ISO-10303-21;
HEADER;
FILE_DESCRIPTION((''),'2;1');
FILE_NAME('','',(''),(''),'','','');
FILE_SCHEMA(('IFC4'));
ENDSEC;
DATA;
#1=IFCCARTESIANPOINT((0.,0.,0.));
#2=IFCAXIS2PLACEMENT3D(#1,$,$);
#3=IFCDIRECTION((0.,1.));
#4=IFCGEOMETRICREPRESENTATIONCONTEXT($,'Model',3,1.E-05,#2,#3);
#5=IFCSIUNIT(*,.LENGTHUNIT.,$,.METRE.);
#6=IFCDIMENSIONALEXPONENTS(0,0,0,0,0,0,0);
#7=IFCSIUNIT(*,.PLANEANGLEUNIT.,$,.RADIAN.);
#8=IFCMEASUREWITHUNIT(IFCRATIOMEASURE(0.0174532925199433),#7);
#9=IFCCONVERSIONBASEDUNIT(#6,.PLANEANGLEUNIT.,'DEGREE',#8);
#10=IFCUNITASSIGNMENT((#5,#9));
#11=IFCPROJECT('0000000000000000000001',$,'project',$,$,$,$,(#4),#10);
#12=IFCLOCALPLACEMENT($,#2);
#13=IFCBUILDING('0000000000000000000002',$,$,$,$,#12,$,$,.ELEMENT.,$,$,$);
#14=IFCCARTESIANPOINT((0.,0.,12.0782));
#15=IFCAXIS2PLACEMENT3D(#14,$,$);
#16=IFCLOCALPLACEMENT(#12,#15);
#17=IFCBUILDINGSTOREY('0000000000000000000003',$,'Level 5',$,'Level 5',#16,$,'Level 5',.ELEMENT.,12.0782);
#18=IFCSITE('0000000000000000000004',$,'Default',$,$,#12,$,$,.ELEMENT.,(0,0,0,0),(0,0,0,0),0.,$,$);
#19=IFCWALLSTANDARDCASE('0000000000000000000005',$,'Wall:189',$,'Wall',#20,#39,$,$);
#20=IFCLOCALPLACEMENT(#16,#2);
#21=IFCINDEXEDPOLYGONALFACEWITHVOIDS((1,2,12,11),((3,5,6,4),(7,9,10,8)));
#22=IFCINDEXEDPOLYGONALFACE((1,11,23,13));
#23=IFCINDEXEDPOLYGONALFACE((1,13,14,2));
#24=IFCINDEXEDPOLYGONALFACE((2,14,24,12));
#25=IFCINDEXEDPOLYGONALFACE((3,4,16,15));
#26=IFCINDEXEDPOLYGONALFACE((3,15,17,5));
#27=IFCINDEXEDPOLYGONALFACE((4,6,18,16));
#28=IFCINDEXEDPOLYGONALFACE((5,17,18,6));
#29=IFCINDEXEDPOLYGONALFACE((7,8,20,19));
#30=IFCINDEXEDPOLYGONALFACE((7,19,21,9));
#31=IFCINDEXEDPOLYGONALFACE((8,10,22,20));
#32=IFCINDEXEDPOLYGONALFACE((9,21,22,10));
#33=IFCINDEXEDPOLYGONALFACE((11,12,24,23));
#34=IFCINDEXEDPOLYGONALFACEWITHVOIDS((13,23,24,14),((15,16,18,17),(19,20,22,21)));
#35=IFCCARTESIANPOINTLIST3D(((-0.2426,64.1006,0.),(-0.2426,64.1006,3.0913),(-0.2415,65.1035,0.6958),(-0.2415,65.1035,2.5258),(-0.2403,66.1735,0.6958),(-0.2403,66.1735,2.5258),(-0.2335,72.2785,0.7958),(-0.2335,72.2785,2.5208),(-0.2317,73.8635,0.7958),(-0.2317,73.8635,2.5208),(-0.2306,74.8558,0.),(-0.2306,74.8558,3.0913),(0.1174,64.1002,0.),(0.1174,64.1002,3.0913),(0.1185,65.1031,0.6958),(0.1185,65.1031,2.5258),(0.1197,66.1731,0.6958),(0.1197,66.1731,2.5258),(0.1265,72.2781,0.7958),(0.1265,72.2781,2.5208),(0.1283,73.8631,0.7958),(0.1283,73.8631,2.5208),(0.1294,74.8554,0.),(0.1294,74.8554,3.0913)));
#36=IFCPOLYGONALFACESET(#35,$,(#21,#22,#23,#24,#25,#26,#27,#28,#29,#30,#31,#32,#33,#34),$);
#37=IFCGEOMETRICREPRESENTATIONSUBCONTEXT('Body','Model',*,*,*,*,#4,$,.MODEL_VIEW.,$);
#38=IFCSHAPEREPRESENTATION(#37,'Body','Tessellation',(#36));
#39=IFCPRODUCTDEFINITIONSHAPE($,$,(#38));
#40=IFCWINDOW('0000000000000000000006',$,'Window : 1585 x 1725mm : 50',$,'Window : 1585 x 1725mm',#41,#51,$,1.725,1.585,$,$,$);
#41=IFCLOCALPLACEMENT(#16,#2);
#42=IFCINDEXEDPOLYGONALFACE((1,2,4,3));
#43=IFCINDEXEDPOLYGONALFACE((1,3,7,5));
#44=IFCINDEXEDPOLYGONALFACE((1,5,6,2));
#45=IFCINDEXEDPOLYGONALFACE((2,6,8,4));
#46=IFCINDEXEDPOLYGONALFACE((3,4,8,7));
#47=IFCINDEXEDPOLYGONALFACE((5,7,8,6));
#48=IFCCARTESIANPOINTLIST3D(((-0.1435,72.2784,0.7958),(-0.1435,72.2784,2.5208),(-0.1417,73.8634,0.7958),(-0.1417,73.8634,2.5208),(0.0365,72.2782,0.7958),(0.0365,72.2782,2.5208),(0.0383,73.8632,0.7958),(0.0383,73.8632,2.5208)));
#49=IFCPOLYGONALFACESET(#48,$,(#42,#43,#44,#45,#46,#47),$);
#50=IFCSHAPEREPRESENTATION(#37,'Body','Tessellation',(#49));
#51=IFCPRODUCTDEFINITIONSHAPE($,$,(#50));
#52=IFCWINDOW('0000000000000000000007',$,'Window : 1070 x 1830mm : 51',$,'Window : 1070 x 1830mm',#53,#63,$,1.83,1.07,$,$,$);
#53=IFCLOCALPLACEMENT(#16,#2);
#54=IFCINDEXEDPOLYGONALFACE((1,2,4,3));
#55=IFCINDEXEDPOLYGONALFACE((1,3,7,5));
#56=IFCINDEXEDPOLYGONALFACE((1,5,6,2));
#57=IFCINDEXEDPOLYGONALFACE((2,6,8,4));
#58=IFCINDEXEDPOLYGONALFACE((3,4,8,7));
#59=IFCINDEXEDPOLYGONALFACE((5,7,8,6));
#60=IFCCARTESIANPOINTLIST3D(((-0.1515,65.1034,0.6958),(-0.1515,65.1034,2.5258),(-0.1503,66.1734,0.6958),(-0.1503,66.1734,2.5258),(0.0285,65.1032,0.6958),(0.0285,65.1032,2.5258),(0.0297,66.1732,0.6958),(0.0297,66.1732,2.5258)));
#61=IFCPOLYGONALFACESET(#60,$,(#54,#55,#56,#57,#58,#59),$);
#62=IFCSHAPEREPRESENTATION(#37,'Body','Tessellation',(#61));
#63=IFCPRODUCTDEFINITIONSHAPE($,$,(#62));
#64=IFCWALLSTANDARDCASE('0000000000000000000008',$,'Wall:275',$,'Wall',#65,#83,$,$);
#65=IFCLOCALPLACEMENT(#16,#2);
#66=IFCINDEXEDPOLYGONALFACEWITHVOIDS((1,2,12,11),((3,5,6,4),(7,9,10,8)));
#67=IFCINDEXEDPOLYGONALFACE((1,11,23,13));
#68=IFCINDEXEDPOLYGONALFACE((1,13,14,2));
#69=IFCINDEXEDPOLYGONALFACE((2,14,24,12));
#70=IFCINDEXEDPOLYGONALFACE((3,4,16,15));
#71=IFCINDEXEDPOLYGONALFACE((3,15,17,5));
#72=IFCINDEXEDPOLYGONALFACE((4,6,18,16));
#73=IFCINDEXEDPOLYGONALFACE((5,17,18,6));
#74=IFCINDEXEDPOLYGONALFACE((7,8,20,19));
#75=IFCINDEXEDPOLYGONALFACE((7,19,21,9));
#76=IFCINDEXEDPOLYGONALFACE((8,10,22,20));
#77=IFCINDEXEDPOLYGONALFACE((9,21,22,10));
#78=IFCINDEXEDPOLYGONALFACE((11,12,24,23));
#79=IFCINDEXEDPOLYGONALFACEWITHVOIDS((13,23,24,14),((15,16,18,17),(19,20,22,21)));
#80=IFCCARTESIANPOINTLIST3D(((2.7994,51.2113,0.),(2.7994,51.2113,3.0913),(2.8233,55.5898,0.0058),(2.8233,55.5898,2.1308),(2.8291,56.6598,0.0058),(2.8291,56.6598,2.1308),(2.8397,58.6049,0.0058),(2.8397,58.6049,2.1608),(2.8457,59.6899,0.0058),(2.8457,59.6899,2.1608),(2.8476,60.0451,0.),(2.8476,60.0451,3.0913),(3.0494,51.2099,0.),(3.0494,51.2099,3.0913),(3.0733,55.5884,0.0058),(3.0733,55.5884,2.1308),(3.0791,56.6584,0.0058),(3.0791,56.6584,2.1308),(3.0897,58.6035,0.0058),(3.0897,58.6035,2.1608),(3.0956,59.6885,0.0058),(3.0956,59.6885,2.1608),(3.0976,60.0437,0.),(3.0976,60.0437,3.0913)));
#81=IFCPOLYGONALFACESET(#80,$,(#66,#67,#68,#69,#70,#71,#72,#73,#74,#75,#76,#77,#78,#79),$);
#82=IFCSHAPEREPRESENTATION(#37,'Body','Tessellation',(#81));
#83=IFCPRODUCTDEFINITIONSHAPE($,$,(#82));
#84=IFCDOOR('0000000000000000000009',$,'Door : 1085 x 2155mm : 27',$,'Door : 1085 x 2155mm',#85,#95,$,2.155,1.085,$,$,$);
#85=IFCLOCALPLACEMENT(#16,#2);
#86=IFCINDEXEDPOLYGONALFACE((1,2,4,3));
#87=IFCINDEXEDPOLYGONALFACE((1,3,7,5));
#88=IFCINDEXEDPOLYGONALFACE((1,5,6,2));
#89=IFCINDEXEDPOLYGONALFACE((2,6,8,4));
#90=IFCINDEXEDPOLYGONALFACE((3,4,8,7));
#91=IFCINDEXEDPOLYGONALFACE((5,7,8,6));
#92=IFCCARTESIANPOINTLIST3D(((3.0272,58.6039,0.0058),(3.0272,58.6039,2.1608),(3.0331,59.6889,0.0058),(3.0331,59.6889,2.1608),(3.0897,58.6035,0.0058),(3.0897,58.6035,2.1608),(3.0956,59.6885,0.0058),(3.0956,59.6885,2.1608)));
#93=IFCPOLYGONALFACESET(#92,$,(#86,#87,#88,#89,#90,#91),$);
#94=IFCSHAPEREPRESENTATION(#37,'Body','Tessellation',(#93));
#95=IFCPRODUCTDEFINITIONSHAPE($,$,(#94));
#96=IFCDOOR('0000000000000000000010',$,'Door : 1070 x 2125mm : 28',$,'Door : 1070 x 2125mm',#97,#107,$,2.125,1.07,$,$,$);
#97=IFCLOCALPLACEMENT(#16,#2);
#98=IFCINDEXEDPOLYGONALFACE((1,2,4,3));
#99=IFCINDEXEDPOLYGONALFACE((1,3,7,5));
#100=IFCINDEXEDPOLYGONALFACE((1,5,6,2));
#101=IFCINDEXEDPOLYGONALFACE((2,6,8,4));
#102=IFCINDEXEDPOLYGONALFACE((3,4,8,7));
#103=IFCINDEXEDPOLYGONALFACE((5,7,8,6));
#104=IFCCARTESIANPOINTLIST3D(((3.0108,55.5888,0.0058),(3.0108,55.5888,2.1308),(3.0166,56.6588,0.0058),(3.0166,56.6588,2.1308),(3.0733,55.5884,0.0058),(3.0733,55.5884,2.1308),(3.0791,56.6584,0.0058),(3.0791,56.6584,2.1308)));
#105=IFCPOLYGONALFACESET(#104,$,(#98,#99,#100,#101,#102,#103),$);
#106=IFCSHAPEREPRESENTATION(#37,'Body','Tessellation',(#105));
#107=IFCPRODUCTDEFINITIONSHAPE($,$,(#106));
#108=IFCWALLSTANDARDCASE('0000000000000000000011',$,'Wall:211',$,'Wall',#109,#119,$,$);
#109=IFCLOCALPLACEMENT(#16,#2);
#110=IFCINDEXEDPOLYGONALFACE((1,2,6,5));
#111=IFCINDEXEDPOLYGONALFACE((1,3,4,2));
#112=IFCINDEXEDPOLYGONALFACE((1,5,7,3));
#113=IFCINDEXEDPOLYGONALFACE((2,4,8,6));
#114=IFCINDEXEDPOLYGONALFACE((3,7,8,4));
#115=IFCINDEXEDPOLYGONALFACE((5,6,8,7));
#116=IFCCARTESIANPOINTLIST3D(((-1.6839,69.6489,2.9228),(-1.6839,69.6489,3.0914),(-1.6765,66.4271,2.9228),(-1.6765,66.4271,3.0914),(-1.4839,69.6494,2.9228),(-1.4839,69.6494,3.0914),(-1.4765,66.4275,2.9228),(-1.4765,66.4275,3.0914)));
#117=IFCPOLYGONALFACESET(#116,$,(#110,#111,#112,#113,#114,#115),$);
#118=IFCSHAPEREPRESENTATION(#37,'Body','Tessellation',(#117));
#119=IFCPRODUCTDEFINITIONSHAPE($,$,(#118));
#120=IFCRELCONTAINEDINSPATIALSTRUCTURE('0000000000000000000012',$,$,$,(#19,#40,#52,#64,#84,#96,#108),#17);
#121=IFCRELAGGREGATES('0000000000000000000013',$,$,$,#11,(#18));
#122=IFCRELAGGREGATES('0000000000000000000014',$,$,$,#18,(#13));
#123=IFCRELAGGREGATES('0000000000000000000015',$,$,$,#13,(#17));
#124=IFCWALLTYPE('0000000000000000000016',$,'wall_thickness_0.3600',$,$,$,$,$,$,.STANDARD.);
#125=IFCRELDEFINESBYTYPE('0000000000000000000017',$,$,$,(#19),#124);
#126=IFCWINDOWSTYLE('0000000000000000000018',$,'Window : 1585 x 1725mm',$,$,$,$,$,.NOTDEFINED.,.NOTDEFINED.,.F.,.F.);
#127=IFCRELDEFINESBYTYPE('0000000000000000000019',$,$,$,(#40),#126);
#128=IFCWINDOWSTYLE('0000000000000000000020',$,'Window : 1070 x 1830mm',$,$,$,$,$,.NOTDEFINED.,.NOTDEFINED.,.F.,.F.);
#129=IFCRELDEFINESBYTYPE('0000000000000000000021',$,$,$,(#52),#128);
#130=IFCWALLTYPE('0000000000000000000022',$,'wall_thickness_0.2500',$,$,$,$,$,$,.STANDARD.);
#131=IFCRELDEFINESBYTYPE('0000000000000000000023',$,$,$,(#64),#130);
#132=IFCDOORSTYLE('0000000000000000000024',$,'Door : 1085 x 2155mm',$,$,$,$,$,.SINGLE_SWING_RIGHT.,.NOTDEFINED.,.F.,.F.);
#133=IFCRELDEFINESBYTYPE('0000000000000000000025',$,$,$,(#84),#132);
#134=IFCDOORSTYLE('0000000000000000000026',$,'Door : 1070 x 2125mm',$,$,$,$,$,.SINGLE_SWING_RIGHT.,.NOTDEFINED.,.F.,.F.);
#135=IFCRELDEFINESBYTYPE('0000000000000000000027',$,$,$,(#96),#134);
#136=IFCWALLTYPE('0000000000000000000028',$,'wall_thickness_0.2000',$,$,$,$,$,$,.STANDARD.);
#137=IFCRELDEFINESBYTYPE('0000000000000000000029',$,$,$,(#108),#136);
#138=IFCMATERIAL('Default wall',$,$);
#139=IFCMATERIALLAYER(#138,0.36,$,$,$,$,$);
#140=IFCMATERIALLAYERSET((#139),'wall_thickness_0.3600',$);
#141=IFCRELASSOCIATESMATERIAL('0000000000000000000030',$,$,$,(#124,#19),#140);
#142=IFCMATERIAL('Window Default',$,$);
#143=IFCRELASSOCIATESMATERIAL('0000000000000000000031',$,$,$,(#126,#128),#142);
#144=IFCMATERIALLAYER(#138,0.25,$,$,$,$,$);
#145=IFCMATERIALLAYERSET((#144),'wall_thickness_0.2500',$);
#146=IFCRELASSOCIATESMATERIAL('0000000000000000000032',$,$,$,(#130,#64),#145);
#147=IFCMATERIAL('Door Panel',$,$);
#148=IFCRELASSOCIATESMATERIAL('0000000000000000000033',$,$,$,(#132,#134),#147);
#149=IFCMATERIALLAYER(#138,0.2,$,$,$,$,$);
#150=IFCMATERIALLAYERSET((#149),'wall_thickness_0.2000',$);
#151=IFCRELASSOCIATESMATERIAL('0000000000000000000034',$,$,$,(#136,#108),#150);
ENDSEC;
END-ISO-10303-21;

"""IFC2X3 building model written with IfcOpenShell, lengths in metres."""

from ifc_helpers import new_model, entity, si_unit, converted_unit, direction, frame, frame_2d, origin, origin_2d_with_axis, place, context, subcontext, project, spatial, polyline, rectangle, outline, extrude, clip, halfspace, source, transform, mapped, material, layer, layer_set, layer_usage, type_object, type_shapes, element, fill, save


model = new_model("IFC2X3")

# Units and contexts
model_context = context("Model", 3, precision=1e-05, world=origin(), true_north=direction((0.0, 1.0)))
body_context = subcontext(model_context, "Body", "Model", "MODEL_VIEW")
ifc_project = project(units=[si_unit("LENGTHUNIT", "METRE"), converted_unit("PLANEANGLEUNIT", "DEGREE", entity("IfcRatioMeasure", 0.0174532925199433), si_unit("PLANEANGLEUNIT", "RADIAN"), dimensions=[0, 0, 0, 0, 0, 0, 0])], contexts=[model_context])

# Site, building, storey
placement_1 = place(None, origin())
site = spatial("IfcSite", under=ifc_project, at=placement_1, Name="Default", CompositionType="ELEMENT", RefLatitude=(0, 0, 0, 0), RefLongitude=(0, 0, 0, 0), RefElevation=0.0)
building = spatial("IfcBuilding", under=site, at=placement_1, CompositionType="ELEMENT")
storey_placement = place(placement_1, frame((0.0, 0.0, 12.0782)))
storey = spatial("IfcBuildingStorey", under=building, at=storey_placement, Name="Level 5", ObjectType="Level 5", LongName="Level 5", CompositionType="ELEMENT", Elevation=12.0782)

# Wall, openings, windows
ifc_material_1 = material(Name="Default wall")
ifc_layer_1 = layer(ifc_material_1, 0.36)
ifc_layer_set_1 = layer_set([ifc_layer_1], Name="wall_thickness_0.3600")
ifc_layer_usage_1 = layer_usage(ifc_layer_set_1, "AXIS2", "POSITIVE", -0.18)
wall_type_1 = type_object("IfcWallType", Name="wall_thickness_0.3600", PredefinedType="STANDARD", material=ifc_layer_set_1)
wall_1_placement = place(storey_placement, frame((-0.0506, 74.8556, 0.0), z_axis=(0.0, 0.0, 1.0), x_axis=(-0.001113, -0.999999, 0.0)))
wall_1 = element("IfcWallStandardCase", 1, at=wall_1_placement, inside=storey, type_object=wall_type_1, material=ifc_layer_usage_1, Name="Wall:189", ObjectType="Wall", context=body_context, shape_type="Clipping", body=[
    clip(extrude(outline(polyline([(10.7552, -0.18), (10.7552, 0.18), (0.0, 0.18), (0.0, -0.18), (10.7552, -0.18)])), origin(), (0.0, 0.0, 1.0), 3.0913), halfspace(frame((-0.9908, -1.1771, 4.0083), z_axis=(-0.000981, -0.389902, 0.920856), x_axis=(0.004529, 0.920844, 0.389905)), False)),
])
opening_1_placement = place(wall_1_placement, frame((0.9923, -0.18, 0.7958)))
opening_1 = element("IfcOpeningElement", 2, at=opening_1_placement, cuts=wall_1, ObjectType="Opening", context=body_context, shape_type="SweptSolid", body=[
    extrude(rectangle(XDim=1.585, YDim=1.725, at=frame_2d((0.8625, 0.7925), x_axis=(0.0, 1.0))), frame((0.0, 0.0, 0.0), z_axis=(0.0, 1.0, 0.0), x_axis=(0.0, 0.0, 1.0)), (0.0, 0.0, 1.0), 0.36),
])
opening_2_placement = place(wall_1_placement, frame((8.6823, -0.18, 0.6958)))
opening_2 = element("IfcOpeningElement", 3, at=opening_2_placement, cuts=wall_1, ObjectType="Opening", context=body_context, shape_type="SweptSolid", body=[
    extrude(rectangle(XDim=1.07, YDim=1.83, at=frame_2d((0.915, 0.535), x_axis=(0.0, 1.0))), frame((0.0, 0.0, 0.0), z_axis=(0.0, 1.0, 0.0), x_axis=(0.0, 0.0, 1.0)), (0.0, 0.0, 1.0), 0.36),
])
ifc_material_2 = material(Name="Window Default")
window_style_1 = type_object("IfcWindowStyle", Name="Window : 1585 x 1725mm", ConstructionType="NOTDEFINED", OperationType="NOTDEFINED", ParameterTakesPrecedence=False, Sizeable=False, material=ifc_material_2)
shared_shape_1 = source(origin(), body_context, "Body", "SweptSolid", [
    extrude(rectangle(XDim=0.18, YDim=1.585, at=origin_2d_with_axis()), frame((0.7925, 0.18, 0.0), z_axis=(0.0, 0.0, 1.0), x_axis=(0.0, 1.0, 0.0)), (0.0, 0.0, 1.0), 1.725),
])
type_shapes(window_style_1, [shared_shape_1])
window_1_placement = place(opening_1_placement, origin())
window_1 = element("IfcWindow", 4, at=window_1_placement, inside=storey, type_object=window_style_1, Name="Window : 1585 x 1725mm : 50", ObjectType="Window : 1585 x 1725mm", OverallHeight=1.725, OverallWidth=1.585, context=body_context, shape_type="MappedRepresentation", body=[
    mapped(shared_shape_1, transform((0.0, 0.0, 0.0), scale=1.0)),
])
fill(opening_1, window_1)
window_style_2 = type_object("IfcWindowStyle", Name="Window : 1070 x 1830mm", ConstructionType="NOTDEFINED", OperationType="NOTDEFINED", ParameterTakesPrecedence=False, Sizeable=False, material=ifc_material_2)
shared_shape_2 = source(origin(), body_context, "Body", "SweptSolid", [
    extrude(rectangle(XDim=0.18, YDim=1.07, at=origin_2d_with_axis()), frame((0.535, 0.18, 0.0), z_axis=(0.0, 0.0, 1.0), x_axis=(0.0, 1.0, 0.0)), (0.0, 0.0, 1.0), 1.83),
])
type_shapes(window_style_2, [shared_shape_2])
window_2_placement = place(opening_2_placement, origin())
window_2 = element("IfcWindow", 5, at=window_2_placement, inside=storey, type_object=window_style_2, Name="Window : 1070 x 1830mm : 51", ObjectType="Window : 1070 x 1830mm", OverallHeight=1.83, OverallWidth=1.07, context=body_context, shape_type="MappedRepresentation", body=[
    mapped(shared_shape_2, transform((0.0, 0.0, 0.0), scale=1.0)),
])
fill(opening_2, window_2)

# Shared definitions
ifc_layer_2 = layer(ifc_material_1, 0.25)
ifc_layer_set_2 = layer_set([ifc_layer_2], Name="wall_thickness_0.2500")
ifc_layer_usage_2 = layer_usage(ifc_layer_set_2, "AXIS2", "POSITIVE", -0.125)
wall_type_2 = type_object("IfcWallType", Name="wall_thickness_0.2500", PredefinedType="STANDARD", material=ifc_layer_set_2)

# Shared definitions
ifc_material_3 = material(Name="Door Panel")

# Wall, openings, doors
wall_2_placement = place(storey_placement, frame((2.9726, 60.0444, 0.0), z_axis=(0.0, 0.0, 1.0), x_axis=(-0.005454, -0.999985, 0.0)))
wall_2 = element("IfcWallStandardCase", 6, at=wall_2_placement, inside=storey, type_object=wall_type_2, material=ifc_layer_usage_2, Name="Wall:275", ObjectType="Wall", context=body_context, shape_type="Clipping", body=[
    clip(clip(extrude(outline(polyline([(8.8339, -0.125), (8.8339, 0.125), (0.0, 0.125), (0.0, -0.125), (8.8339, -0.125)])), origin(), (0.0, 0.0, 1.0), 3.0913), halfspace(frame((-15.7802, -4.2854, 4.0083), z_axis=(0.000711, -0.389903, 0.920856), x_axis=(0.000531, 0.920855, 0.389905)), False)), halfspace(frame((2.3231, -15.7134, 9.0175), z_axis=(0.391125, -0.001752, 0.920336), x_axis=(0.002692, 0.999996, 0.000759)), False)),
])
opening_3_placement = place(wall_2_placement, frame((0.3552, -0.125, 0.0058)))
opening_3 = element("IfcOpeningElement", 7, at=opening_3_placement, cuts=wall_2, ObjectType="Opening", context=body_context, shape_type="SweptSolid", body=[
    extrude(rectangle(XDim=1.085, YDim=2.155, at=frame_2d((1.0775, 0.5425), x_axis=(0.0, 1.0))), frame((0.0, 0.0, 0.0), z_axis=(0.0, 1.0, 0.0), x_axis=(0.0, 0.0, 1.0)), (0.0, 0.0, 1.0), 0.25),
])
opening_4_placement = place(wall_2_placement, frame((3.3854, -0.125, 0.0058)))
opening_4 = element("IfcOpeningElement", 8, at=opening_4_placement, cuts=wall_2, ObjectType="Opening", context=body_context, shape_type="SweptSolid", body=[
    extrude(rectangle(XDim=1.07, YDim=2.125, at=frame_2d((1.0625, 0.535), x_axis=(0.0, 1.0))), frame((0.0, 0.0, 0.0), z_axis=(0.0, 1.0, 0.0), x_axis=(0.0, 0.0, 1.0)), (0.0, 0.0, 1.0), 0.25),
])
door_style_1 = type_object("IfcDoorStyle", Name="Door : 1085 x 2155mm", ConstructionType="NOTDEFINED", OperationType="SINGLE_SWING_RIGHT", ParameterTakesPrecedence=False, Sizeable=False, material=ifc_material_3)
shared_shape_3 = source(origin(), body_context, "Body", "SweptSolid", [
    extrude(rectangle(XDim=0.0625, YDim=1.085, at=origin_2d_with_axis()), frame((0.5425, 0.2188, 0.0), z_axis=(0.0, 0.0, 1.0), x_axis=(0.0, 1.0, 0.0)), (0.0, 0.0, 1.0), 2.155),
])
type_shapes(door_style_1, [shared_shape_3])
door_1_placement = place(opening_3_placement, origin())
door_1 = element("IfcDoor", 9, at=door_1_placement, inside=storey, type_object=door_style_1, Name="Door : 1085 x 2155mm : 27", ObjectType="Door : 1085 x 2155mm", OverallHeight=2.155, OverallWidth=1.085, context=body_context, shape_type="MappedRepresentation", body=[
    mapped(shared_shape_3, transform((0.0, 0.0, 0.0), scale=1.0)),
])
fill(opening_3, door_1)
door_style_2 = type_object("IfcDoorStyle", Name="Door : 1070 x 2125mm", ConstructionType="NOTDEFINED", OperationType="SINGLE_SWING_RIGHT", ParameterTakesPrecedence=False, Sizeable=False, material=ifc_material_3)
shared_shape_4 = source(origin(), body_context, "Body", "SweptSolid", [
    extrude(rectangle(XDim=0.0625, YDim=1.07, at=origin_2d_with_axis()), frame((0.535, 0.2188, 0.0), z_axis=(0.0, 0.0, 1.0), x_axis=(0.0, 1.0, 0.0)), (0.0, 0.0, 1.0), 2.125),
])
type_shapes(door_style_2, [shared_shape_4])
door_2_placement = place(opening_4_placement, origin())
door_2 = element("IfcDoor", 10, at=door_2_placement, inside=storey, type_object=door_style_2, Name="Door : 1070 x 2125mm : 28", ObjectType="Door : 1070 x 2125mm", OverallHeight=2.125, OverallWidth=1.07, context=body_context, shape_type="MappedRepresentation", body=[
    mapped(shared_shape_4, transform((0.0, 0.0, 0.0), scale=1.0)),
])
fill(opening_4, door_2)

# Wall
ifc_layer_3 = layer(ifc_material_1, 0.2)
ifc_layer_set_3 = layer_set([ifc_layer_3], Name="wall_thickness_0.2000")
ifc_layer_usage_3 = layer_usage(ifc_layer_set_3, "AXIS2", "POSITIVE", -0.1)
wall_type_3 = type_object("IfcWallType", Name="wall_thickness_0.2000", PredefinedType="STANDARD", material=ifc_layer_set_3)
placement_2 = place(placement_1, frame((0.0, 0.0, 15.001)))
wall_3_placement = place(placement_2, frame((-1.5839, 69.6491, 0.0), z_axis=(0.0, 0.0, 1.0), x_axis=(0.002283, -0.999997, 0.0)))
element("IfcWallStandardCase", 11, at=wall_3_placement, inside=storey, type_object=wall_type_3, material=ifc_layer_usage_3, Name="Wall:211", ObjectType="Wall", context=body_context, shape_type="SweptSolid", body=[
    extrude(outline(polyline([(3.2219, -0.1), (3.2219, 0.1), (0.0, 0.1), (0.0, -0.1), (3.2219, -0.1)])), origin(), (0.0, 0.0, 1.0), 0.1686),
])

save(model, "model.ifc")
